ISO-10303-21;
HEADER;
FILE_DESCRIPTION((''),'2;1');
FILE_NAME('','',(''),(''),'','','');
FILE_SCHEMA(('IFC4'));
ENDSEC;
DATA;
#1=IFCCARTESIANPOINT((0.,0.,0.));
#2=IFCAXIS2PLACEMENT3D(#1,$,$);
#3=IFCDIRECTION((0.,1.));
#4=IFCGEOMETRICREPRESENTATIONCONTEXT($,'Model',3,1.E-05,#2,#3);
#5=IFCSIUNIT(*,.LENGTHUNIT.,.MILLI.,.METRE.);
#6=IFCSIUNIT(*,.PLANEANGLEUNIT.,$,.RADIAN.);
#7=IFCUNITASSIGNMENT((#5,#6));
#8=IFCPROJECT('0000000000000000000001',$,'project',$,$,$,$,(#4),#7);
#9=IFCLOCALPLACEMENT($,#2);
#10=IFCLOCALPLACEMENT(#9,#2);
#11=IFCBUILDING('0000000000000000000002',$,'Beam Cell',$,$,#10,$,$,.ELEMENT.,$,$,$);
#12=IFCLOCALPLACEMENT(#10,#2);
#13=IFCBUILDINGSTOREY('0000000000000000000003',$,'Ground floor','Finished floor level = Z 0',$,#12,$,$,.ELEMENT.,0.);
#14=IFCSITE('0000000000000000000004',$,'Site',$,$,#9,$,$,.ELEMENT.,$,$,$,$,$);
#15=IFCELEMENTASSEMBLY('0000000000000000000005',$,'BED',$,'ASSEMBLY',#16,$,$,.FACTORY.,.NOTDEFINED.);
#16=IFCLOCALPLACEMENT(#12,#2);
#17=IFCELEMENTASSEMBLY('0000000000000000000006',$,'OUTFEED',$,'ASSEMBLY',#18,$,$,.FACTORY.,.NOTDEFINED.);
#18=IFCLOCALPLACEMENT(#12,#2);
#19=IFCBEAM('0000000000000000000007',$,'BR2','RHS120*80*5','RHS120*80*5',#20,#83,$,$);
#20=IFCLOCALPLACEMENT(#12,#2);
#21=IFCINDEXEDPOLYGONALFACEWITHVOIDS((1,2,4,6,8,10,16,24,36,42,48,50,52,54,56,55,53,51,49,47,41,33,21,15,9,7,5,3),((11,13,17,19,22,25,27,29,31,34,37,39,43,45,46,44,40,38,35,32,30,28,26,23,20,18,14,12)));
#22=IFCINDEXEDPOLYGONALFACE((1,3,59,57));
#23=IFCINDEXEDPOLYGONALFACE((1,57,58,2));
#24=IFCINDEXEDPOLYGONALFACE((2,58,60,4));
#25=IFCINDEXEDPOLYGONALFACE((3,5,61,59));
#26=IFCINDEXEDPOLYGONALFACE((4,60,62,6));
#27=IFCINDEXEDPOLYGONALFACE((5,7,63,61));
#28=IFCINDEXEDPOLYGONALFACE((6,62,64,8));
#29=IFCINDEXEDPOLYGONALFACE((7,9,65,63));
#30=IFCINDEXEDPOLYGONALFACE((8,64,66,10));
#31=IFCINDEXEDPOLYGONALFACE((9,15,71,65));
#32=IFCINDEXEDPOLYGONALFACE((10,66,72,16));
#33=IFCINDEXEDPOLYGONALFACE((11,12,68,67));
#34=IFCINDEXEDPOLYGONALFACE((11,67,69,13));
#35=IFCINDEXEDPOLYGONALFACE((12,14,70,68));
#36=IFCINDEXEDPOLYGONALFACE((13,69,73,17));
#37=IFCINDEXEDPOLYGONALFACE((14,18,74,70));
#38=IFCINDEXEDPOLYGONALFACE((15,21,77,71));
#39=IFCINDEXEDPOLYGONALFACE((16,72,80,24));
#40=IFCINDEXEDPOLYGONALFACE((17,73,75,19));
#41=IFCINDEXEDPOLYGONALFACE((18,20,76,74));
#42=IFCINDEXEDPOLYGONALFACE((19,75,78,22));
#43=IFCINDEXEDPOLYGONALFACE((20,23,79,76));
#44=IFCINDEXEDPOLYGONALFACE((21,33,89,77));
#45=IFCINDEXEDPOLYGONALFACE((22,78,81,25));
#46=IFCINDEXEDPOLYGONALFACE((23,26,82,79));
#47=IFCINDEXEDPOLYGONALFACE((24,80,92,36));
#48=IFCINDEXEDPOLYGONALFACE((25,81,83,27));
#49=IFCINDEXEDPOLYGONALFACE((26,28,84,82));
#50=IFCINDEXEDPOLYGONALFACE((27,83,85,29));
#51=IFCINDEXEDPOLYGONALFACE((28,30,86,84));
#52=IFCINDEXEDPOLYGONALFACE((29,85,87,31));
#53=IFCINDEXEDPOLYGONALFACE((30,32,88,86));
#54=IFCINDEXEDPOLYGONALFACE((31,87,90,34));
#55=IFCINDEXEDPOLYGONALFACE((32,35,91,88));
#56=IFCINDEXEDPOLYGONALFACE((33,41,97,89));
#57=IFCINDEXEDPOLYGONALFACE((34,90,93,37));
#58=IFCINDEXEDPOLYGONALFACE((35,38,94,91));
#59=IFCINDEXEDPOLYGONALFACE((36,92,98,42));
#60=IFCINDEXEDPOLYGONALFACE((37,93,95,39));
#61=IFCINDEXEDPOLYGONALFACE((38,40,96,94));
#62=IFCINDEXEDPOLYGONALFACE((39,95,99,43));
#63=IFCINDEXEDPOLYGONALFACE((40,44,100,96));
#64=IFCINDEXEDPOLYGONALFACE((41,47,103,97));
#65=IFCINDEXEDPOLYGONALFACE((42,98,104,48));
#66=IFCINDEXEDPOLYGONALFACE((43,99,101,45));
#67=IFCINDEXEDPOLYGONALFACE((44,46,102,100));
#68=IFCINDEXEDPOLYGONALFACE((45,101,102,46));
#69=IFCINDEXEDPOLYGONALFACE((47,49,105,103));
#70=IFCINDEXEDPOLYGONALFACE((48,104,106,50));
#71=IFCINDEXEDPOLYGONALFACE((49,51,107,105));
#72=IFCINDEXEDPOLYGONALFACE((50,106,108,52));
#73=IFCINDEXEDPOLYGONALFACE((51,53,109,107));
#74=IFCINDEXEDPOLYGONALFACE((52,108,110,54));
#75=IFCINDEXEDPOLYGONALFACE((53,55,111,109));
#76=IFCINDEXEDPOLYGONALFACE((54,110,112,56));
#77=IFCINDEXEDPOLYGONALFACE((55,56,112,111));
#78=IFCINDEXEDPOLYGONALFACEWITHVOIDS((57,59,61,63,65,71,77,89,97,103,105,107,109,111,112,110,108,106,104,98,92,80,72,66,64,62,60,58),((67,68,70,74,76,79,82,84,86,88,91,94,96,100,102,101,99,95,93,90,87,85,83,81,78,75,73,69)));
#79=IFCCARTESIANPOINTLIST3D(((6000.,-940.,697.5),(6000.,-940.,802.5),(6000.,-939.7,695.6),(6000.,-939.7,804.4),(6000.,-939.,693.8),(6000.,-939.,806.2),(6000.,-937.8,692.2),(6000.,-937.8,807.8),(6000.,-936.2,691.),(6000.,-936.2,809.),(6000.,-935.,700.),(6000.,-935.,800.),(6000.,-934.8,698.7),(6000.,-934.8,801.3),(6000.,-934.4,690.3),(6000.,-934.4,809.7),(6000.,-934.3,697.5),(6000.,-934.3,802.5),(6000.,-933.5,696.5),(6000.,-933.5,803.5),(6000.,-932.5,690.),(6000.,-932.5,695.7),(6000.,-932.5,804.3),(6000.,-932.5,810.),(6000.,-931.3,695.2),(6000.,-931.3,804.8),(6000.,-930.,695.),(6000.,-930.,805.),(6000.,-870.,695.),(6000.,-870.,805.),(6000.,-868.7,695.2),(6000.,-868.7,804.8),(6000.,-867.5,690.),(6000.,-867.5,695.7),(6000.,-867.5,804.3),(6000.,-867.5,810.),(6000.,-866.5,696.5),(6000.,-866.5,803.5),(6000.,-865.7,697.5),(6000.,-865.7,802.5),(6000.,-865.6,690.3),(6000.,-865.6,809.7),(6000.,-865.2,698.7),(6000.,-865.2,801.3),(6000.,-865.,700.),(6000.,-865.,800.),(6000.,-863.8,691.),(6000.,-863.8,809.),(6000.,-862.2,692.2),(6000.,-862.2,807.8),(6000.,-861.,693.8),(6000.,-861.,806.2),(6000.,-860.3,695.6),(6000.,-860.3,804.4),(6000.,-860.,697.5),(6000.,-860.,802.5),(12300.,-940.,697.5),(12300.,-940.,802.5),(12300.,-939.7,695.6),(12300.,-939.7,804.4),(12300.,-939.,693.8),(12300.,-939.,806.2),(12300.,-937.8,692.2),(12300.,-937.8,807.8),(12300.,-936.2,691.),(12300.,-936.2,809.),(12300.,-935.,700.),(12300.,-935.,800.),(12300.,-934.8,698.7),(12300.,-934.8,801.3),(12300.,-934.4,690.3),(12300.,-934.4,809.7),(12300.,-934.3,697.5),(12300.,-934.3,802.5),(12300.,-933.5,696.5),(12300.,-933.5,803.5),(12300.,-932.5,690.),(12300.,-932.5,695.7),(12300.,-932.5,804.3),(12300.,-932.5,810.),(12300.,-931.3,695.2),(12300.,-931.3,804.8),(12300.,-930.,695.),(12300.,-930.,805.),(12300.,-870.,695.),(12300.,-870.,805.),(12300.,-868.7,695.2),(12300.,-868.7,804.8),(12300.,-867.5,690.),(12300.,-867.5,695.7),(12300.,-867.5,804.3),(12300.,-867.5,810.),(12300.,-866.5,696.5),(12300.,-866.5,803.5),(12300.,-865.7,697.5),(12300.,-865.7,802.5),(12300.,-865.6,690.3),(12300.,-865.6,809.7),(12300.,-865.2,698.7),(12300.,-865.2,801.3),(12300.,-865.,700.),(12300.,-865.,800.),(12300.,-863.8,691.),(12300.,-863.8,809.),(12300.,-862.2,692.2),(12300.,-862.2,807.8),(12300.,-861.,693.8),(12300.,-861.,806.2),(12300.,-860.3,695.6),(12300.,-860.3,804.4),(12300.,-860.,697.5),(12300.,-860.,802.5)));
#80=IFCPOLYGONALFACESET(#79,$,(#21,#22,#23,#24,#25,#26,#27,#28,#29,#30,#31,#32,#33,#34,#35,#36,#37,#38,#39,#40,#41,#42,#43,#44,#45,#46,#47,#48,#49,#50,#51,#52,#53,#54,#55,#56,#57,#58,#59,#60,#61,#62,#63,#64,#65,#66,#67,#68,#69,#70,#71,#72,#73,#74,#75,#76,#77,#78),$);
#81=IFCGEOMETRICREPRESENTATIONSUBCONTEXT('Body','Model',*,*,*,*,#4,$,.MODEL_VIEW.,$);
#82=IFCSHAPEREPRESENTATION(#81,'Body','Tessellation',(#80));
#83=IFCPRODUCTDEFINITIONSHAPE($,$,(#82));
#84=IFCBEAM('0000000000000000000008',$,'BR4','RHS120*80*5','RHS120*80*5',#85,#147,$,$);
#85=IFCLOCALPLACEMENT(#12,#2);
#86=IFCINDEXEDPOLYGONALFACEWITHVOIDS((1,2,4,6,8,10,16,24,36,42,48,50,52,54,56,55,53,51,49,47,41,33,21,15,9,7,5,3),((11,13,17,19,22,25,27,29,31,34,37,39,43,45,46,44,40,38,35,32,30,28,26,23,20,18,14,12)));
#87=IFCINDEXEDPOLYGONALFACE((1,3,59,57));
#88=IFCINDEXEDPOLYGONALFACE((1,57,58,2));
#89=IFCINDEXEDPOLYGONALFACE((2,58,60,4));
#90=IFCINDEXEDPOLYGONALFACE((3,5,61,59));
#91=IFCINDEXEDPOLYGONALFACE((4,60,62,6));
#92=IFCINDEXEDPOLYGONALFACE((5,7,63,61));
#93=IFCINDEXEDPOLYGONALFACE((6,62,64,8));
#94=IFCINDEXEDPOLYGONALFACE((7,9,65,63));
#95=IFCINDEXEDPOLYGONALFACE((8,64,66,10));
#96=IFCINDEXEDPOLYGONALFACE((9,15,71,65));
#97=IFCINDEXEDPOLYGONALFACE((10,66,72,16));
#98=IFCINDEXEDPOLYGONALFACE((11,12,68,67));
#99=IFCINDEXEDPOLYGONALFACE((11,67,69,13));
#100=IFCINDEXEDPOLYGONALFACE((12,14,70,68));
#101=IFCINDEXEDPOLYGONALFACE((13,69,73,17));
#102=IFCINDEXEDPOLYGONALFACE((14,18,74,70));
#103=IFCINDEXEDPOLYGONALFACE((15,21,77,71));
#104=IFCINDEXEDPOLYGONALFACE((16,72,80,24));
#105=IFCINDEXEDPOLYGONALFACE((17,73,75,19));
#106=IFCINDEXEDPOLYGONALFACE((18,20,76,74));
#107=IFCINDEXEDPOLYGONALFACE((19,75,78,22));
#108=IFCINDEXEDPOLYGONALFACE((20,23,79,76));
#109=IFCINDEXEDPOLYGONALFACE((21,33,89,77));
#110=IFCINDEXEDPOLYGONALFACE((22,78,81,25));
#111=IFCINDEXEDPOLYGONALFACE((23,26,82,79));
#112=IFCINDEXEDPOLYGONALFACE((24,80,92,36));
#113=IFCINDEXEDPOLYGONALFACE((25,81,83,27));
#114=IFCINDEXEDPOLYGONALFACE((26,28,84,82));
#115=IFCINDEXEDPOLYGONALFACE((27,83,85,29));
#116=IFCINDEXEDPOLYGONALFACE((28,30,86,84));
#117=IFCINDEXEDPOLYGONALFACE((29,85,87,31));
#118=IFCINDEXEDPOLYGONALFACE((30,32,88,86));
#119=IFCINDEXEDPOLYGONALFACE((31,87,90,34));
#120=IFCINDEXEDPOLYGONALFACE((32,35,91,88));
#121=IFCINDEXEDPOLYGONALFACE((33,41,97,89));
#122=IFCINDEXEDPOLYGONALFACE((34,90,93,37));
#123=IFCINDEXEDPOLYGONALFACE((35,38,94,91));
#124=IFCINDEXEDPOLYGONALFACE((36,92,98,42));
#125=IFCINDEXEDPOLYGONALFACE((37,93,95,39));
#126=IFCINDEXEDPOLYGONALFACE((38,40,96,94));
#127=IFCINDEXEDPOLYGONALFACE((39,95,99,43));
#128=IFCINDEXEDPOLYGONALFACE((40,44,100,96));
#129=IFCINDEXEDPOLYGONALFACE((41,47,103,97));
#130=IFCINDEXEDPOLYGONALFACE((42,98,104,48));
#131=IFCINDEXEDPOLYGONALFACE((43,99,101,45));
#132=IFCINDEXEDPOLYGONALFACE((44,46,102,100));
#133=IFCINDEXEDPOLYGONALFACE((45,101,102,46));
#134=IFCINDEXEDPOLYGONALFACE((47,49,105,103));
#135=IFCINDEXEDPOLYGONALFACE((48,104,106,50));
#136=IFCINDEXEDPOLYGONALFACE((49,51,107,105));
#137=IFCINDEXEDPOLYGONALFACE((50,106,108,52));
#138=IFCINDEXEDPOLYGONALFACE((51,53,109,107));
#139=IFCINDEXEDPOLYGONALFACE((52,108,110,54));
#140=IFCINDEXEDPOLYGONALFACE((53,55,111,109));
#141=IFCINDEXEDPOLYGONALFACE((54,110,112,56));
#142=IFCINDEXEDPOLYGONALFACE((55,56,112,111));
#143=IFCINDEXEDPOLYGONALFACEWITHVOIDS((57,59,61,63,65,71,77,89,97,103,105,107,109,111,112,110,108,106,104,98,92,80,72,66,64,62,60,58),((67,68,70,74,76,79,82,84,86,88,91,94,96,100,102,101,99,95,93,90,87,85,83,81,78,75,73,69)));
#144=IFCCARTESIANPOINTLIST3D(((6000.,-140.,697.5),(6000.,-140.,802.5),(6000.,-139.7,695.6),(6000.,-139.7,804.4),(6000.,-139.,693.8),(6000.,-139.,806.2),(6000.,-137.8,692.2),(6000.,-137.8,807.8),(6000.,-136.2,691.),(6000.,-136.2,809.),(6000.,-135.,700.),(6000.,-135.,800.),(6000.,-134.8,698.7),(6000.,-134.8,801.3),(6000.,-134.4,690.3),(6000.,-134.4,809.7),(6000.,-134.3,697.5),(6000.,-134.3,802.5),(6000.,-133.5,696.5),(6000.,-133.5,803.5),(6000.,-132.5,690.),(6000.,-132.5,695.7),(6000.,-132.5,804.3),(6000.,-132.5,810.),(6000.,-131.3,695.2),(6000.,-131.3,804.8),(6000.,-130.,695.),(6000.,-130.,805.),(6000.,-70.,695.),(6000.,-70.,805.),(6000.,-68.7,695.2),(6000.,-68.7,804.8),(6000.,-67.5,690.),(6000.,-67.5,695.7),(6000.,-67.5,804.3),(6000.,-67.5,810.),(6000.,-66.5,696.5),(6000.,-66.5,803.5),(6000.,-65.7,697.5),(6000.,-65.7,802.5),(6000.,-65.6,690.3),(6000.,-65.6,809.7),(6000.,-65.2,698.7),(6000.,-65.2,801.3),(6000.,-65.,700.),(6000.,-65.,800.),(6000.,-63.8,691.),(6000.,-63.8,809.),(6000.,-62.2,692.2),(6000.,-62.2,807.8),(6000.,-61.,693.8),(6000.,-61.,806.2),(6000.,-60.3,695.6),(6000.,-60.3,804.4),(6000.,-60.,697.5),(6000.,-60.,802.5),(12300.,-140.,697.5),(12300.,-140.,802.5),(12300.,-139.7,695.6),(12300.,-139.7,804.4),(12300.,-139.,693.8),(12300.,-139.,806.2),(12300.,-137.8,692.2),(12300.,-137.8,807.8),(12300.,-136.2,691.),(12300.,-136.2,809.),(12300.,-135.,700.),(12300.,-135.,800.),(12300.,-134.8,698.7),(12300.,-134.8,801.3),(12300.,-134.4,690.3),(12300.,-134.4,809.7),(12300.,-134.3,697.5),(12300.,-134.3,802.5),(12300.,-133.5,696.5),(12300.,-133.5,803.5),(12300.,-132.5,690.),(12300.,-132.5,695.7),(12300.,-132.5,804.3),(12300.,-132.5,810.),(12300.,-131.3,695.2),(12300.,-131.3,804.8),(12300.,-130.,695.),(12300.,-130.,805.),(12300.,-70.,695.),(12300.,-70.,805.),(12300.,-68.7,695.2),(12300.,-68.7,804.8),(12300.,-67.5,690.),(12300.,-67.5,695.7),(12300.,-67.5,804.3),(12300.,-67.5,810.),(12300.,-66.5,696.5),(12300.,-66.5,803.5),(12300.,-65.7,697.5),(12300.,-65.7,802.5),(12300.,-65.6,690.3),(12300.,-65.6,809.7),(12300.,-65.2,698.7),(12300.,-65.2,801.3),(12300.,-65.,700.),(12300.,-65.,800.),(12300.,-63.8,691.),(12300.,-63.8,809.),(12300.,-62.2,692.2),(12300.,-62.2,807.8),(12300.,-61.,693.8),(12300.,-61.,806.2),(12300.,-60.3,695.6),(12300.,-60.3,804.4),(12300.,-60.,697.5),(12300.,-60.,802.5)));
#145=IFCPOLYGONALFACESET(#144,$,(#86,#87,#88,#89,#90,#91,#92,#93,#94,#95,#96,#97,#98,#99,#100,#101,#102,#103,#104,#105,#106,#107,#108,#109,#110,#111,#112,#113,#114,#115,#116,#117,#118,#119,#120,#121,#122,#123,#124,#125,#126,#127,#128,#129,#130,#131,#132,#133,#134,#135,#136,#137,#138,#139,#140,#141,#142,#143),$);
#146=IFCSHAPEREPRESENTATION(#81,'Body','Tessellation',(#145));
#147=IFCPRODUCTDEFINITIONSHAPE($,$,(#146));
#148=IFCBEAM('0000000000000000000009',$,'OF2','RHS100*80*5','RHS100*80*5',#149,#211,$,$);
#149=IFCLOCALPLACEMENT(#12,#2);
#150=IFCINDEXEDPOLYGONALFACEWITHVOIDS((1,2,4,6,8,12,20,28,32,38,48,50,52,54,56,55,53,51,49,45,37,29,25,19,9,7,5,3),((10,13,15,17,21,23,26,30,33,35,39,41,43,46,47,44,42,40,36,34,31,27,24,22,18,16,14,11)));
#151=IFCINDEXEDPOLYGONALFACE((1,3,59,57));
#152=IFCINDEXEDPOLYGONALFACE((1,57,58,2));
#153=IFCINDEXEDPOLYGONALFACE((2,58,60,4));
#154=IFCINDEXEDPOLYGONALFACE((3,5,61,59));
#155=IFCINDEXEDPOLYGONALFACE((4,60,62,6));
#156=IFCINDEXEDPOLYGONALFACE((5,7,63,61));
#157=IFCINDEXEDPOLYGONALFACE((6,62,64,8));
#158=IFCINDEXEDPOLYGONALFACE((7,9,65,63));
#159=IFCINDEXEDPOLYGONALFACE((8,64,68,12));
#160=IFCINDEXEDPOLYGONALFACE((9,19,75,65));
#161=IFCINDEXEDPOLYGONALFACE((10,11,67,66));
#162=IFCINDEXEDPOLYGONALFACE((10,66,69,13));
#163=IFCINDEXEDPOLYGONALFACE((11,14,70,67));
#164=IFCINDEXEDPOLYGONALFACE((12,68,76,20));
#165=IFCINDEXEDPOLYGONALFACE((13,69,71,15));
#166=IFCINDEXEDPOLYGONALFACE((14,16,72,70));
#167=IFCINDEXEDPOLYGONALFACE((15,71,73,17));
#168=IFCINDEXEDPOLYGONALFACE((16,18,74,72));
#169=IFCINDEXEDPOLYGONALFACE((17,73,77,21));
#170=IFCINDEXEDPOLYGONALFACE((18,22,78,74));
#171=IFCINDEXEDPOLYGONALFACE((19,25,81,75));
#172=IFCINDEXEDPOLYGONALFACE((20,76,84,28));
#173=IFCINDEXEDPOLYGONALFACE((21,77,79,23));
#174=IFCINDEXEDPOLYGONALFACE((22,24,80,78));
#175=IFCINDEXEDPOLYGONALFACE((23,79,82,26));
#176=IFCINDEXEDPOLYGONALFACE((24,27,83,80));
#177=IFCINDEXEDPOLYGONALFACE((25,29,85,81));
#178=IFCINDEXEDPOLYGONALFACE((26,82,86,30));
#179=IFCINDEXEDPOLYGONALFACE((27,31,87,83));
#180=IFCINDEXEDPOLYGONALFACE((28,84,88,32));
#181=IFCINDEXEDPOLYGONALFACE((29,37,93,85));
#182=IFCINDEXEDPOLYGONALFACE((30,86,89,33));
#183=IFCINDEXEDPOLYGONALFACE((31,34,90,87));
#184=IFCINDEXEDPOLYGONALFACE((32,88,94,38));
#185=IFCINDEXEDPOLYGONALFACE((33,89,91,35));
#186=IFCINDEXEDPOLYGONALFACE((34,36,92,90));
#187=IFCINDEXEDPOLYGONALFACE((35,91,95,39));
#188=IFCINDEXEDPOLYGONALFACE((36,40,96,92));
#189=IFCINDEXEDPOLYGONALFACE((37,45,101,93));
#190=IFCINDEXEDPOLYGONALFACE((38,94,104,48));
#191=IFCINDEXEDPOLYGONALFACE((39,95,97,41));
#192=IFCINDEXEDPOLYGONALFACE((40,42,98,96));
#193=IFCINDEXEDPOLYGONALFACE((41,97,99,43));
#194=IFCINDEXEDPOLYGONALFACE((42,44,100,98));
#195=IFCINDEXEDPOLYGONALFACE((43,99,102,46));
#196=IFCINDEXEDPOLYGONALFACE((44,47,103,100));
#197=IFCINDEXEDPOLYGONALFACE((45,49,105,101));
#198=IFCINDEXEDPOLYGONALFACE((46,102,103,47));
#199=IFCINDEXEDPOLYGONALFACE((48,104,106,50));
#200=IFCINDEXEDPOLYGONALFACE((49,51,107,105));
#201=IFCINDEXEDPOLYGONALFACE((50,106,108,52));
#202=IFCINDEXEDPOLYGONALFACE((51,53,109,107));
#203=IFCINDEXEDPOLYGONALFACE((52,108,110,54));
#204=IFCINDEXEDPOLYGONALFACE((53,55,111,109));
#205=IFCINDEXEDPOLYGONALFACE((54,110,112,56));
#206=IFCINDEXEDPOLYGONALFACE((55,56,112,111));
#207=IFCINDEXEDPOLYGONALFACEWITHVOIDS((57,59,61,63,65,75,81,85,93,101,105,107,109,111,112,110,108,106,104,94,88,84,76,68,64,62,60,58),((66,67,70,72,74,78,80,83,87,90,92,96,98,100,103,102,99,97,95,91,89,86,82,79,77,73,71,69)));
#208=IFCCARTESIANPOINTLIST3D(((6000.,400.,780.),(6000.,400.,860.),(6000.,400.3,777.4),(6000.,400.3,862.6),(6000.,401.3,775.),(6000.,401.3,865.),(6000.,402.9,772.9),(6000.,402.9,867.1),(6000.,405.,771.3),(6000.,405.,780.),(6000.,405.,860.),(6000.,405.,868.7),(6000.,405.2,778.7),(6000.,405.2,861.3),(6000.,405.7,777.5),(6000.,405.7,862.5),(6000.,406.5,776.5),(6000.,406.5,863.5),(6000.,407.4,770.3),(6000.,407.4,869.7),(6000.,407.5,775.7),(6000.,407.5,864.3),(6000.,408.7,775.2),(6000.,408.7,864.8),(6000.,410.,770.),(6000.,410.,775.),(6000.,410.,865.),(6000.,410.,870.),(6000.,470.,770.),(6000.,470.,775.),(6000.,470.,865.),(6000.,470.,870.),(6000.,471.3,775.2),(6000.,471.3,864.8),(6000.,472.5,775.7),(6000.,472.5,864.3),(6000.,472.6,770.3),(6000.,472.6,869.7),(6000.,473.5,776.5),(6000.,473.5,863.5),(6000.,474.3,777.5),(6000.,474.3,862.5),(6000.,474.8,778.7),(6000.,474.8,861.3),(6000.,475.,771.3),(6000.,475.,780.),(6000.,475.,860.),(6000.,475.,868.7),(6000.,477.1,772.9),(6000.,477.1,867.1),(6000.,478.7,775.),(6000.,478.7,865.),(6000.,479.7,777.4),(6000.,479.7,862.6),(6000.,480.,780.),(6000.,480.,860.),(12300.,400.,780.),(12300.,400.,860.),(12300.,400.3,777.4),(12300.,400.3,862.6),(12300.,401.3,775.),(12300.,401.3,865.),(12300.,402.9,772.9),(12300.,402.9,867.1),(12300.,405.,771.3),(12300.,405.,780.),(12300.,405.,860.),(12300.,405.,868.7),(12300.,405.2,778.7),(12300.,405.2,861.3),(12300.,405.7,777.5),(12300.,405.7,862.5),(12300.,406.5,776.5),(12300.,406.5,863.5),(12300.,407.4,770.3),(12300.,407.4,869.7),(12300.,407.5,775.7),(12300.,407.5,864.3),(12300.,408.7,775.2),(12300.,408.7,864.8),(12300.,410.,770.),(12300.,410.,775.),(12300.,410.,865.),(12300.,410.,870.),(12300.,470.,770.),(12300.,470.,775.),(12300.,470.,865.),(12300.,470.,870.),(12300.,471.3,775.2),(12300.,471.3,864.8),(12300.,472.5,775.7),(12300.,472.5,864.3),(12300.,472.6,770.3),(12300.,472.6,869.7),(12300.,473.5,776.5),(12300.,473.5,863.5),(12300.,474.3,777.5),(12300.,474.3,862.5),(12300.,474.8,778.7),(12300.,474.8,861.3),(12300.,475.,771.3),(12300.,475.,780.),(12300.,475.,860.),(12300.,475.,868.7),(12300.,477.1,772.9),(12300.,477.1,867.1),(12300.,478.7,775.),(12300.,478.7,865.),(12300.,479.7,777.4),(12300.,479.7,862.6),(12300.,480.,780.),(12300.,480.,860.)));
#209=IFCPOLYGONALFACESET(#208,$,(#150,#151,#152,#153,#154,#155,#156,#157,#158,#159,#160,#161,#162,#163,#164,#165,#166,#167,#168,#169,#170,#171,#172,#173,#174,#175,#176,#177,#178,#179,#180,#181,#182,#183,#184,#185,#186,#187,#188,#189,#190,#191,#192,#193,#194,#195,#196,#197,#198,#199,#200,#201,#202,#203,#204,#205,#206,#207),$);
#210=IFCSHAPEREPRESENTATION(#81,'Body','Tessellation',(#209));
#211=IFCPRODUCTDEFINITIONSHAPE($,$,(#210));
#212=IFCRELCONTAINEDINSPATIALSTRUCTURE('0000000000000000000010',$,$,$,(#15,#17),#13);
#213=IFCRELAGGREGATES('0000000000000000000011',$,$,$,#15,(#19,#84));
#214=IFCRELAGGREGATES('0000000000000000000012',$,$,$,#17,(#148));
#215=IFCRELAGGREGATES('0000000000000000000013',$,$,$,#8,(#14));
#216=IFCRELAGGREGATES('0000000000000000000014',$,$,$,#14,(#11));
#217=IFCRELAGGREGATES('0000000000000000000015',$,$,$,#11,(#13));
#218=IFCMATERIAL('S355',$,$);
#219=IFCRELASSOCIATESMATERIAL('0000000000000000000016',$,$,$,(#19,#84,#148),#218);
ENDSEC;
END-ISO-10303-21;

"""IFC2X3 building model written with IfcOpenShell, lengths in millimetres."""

from ifc_helpers import new_model, si_unit, direction, frame, origin, origin_2d, place, context, subcontext, project, spatial, hollow_rectangle, extrude, material, element, aggregate, save


model = new_model("IFC2X3")

# Units and contexts
model_context = context("Model", 3, precision=1e-05, world=origin(), true_north=direction((0.0, 1.0)))
body_context = subcontext(model_context, "Body", "Model", "MODEL_VIEW")
ifc_project = project(units=[si_unit("LENGTHUNIT", "METRE", prefix="MILLI"), si_unit("PLANEANGLEUNIT", "RADIAN")], contexts=[model_context])

# Site, building, storey
site_placement = place(None, origin())
site = spatial("IfcSite", under=ifc_project, at=site_placement, Name="Site", CompositionType="ELEMENT")
building_placement = place(site_placement, origin())
building = spatial("IfcBuilding", under=site, at=building_placement, Name="Beam Cell", CompositionType="ELEMENT")
storey_placement = place(building_placement, origin())
storey = spatial("IfcBuildingStorey", under=building, at=storey_placement, Name="Ground floor", Description="Finished floor level = Z 0", CompositionType="ELEMENT", Elevation=0.0)

# Shared definitions
ifc_material = material(Name="S355")

# Element assemblies
assembly_1_placement = place(storey_placement, origin())
assembly_1 = element("IfcElementAssembly", 1, at=assembly_1_placement, inside=storey, Name="BED", ObjectType="ASSEMBLY", AssemblyPlace="FACTORY", PredefinedType="NOTDEFINED")
assembly_2_placement = place(storey_placement, origin())
assembly_2 = element("IfcElementAssembly", 2, at=assembly_2_placement, inside=storey, Name="OUTFEED", ObjectType="ASSEMBLY", AssemblyPlace="FACTORY", PredefinedType="NOTDEFINED")

# Beams
beam_1_placement = place(storey_placement, frame((6000.0, -900.0, 750.0), z_axis=(1.0, 0.0, 0.0), x_axis=(0.0, 1.0, 0.0)))
beam_1 = element("IfcBeam", 3, at=beam_1_placement, material=ifc_material, Name="BR2", Description="RHS120*80*5", ObjectType="RHS120*80*5", context=body_context, shape_type="SweptSolid", body=[
    extrude(hollow_rectangle(XDim=80.0, YDim=120.0, WallThickness=5.0, InnerFilletRadius=5.0, OuterFilletRadius=7.5, at=origin_2d()), origin(), (0.0, 0.0, 1.0), 6300.0),
])
beam_2_placement = place(storey_placement, frame((6000.0, -100.0, 750.0), z_axis=(1.0, 0.0, 0.0), x_axis=(0.0, 1.0, 0.0)))
beam_2 = element("IfcBeam", 4, at=beam_2_placement, material=ifc_material, Name="BR4", Description="RHS120*80*5", ObjectType="RHS120*80*5", context=body_context, shape_type="SweptSolid", body=[
    extrude(hollow_rectangle(XDim=80.0, YDim=120.0, WallThickness=5.0, InnerFilletRadius=5.0, OuterFilletRadius=7.5, at=origin_2d()), origin(), (0.0, 0.0, 1.0), 6300.0),
])
aggregate(assembly_1, [beam_1, beam_2])
beam_3_placement = place(storey_placement, frame((6000.0, 440.0, 820.0), z_axis=(1.0, 0.0, 0.0), x_axis=(0.0, 1.0, 0.0)))
beam_3 = element("IfcBeam", 5, at=beam_3_placement, material=ifc_material, Name="OF2", Description="RHS100*80*5", ObjectType="RHS100*80*5", context=body_context, shape_type="SweptSolid", body=[
    extrude(hollow_rectangle(XDim=80.0, YDim=100.0, WallThickness=5.0, InnerFilletRadius=5.0, OuterFilletRadius=10.0, at=origin_2d()), origin(), (0.0, 0.0, 1.0), 6300.0),
])
aggregate(assembly_2, [beam_3])

save(model, "model.ifc")
